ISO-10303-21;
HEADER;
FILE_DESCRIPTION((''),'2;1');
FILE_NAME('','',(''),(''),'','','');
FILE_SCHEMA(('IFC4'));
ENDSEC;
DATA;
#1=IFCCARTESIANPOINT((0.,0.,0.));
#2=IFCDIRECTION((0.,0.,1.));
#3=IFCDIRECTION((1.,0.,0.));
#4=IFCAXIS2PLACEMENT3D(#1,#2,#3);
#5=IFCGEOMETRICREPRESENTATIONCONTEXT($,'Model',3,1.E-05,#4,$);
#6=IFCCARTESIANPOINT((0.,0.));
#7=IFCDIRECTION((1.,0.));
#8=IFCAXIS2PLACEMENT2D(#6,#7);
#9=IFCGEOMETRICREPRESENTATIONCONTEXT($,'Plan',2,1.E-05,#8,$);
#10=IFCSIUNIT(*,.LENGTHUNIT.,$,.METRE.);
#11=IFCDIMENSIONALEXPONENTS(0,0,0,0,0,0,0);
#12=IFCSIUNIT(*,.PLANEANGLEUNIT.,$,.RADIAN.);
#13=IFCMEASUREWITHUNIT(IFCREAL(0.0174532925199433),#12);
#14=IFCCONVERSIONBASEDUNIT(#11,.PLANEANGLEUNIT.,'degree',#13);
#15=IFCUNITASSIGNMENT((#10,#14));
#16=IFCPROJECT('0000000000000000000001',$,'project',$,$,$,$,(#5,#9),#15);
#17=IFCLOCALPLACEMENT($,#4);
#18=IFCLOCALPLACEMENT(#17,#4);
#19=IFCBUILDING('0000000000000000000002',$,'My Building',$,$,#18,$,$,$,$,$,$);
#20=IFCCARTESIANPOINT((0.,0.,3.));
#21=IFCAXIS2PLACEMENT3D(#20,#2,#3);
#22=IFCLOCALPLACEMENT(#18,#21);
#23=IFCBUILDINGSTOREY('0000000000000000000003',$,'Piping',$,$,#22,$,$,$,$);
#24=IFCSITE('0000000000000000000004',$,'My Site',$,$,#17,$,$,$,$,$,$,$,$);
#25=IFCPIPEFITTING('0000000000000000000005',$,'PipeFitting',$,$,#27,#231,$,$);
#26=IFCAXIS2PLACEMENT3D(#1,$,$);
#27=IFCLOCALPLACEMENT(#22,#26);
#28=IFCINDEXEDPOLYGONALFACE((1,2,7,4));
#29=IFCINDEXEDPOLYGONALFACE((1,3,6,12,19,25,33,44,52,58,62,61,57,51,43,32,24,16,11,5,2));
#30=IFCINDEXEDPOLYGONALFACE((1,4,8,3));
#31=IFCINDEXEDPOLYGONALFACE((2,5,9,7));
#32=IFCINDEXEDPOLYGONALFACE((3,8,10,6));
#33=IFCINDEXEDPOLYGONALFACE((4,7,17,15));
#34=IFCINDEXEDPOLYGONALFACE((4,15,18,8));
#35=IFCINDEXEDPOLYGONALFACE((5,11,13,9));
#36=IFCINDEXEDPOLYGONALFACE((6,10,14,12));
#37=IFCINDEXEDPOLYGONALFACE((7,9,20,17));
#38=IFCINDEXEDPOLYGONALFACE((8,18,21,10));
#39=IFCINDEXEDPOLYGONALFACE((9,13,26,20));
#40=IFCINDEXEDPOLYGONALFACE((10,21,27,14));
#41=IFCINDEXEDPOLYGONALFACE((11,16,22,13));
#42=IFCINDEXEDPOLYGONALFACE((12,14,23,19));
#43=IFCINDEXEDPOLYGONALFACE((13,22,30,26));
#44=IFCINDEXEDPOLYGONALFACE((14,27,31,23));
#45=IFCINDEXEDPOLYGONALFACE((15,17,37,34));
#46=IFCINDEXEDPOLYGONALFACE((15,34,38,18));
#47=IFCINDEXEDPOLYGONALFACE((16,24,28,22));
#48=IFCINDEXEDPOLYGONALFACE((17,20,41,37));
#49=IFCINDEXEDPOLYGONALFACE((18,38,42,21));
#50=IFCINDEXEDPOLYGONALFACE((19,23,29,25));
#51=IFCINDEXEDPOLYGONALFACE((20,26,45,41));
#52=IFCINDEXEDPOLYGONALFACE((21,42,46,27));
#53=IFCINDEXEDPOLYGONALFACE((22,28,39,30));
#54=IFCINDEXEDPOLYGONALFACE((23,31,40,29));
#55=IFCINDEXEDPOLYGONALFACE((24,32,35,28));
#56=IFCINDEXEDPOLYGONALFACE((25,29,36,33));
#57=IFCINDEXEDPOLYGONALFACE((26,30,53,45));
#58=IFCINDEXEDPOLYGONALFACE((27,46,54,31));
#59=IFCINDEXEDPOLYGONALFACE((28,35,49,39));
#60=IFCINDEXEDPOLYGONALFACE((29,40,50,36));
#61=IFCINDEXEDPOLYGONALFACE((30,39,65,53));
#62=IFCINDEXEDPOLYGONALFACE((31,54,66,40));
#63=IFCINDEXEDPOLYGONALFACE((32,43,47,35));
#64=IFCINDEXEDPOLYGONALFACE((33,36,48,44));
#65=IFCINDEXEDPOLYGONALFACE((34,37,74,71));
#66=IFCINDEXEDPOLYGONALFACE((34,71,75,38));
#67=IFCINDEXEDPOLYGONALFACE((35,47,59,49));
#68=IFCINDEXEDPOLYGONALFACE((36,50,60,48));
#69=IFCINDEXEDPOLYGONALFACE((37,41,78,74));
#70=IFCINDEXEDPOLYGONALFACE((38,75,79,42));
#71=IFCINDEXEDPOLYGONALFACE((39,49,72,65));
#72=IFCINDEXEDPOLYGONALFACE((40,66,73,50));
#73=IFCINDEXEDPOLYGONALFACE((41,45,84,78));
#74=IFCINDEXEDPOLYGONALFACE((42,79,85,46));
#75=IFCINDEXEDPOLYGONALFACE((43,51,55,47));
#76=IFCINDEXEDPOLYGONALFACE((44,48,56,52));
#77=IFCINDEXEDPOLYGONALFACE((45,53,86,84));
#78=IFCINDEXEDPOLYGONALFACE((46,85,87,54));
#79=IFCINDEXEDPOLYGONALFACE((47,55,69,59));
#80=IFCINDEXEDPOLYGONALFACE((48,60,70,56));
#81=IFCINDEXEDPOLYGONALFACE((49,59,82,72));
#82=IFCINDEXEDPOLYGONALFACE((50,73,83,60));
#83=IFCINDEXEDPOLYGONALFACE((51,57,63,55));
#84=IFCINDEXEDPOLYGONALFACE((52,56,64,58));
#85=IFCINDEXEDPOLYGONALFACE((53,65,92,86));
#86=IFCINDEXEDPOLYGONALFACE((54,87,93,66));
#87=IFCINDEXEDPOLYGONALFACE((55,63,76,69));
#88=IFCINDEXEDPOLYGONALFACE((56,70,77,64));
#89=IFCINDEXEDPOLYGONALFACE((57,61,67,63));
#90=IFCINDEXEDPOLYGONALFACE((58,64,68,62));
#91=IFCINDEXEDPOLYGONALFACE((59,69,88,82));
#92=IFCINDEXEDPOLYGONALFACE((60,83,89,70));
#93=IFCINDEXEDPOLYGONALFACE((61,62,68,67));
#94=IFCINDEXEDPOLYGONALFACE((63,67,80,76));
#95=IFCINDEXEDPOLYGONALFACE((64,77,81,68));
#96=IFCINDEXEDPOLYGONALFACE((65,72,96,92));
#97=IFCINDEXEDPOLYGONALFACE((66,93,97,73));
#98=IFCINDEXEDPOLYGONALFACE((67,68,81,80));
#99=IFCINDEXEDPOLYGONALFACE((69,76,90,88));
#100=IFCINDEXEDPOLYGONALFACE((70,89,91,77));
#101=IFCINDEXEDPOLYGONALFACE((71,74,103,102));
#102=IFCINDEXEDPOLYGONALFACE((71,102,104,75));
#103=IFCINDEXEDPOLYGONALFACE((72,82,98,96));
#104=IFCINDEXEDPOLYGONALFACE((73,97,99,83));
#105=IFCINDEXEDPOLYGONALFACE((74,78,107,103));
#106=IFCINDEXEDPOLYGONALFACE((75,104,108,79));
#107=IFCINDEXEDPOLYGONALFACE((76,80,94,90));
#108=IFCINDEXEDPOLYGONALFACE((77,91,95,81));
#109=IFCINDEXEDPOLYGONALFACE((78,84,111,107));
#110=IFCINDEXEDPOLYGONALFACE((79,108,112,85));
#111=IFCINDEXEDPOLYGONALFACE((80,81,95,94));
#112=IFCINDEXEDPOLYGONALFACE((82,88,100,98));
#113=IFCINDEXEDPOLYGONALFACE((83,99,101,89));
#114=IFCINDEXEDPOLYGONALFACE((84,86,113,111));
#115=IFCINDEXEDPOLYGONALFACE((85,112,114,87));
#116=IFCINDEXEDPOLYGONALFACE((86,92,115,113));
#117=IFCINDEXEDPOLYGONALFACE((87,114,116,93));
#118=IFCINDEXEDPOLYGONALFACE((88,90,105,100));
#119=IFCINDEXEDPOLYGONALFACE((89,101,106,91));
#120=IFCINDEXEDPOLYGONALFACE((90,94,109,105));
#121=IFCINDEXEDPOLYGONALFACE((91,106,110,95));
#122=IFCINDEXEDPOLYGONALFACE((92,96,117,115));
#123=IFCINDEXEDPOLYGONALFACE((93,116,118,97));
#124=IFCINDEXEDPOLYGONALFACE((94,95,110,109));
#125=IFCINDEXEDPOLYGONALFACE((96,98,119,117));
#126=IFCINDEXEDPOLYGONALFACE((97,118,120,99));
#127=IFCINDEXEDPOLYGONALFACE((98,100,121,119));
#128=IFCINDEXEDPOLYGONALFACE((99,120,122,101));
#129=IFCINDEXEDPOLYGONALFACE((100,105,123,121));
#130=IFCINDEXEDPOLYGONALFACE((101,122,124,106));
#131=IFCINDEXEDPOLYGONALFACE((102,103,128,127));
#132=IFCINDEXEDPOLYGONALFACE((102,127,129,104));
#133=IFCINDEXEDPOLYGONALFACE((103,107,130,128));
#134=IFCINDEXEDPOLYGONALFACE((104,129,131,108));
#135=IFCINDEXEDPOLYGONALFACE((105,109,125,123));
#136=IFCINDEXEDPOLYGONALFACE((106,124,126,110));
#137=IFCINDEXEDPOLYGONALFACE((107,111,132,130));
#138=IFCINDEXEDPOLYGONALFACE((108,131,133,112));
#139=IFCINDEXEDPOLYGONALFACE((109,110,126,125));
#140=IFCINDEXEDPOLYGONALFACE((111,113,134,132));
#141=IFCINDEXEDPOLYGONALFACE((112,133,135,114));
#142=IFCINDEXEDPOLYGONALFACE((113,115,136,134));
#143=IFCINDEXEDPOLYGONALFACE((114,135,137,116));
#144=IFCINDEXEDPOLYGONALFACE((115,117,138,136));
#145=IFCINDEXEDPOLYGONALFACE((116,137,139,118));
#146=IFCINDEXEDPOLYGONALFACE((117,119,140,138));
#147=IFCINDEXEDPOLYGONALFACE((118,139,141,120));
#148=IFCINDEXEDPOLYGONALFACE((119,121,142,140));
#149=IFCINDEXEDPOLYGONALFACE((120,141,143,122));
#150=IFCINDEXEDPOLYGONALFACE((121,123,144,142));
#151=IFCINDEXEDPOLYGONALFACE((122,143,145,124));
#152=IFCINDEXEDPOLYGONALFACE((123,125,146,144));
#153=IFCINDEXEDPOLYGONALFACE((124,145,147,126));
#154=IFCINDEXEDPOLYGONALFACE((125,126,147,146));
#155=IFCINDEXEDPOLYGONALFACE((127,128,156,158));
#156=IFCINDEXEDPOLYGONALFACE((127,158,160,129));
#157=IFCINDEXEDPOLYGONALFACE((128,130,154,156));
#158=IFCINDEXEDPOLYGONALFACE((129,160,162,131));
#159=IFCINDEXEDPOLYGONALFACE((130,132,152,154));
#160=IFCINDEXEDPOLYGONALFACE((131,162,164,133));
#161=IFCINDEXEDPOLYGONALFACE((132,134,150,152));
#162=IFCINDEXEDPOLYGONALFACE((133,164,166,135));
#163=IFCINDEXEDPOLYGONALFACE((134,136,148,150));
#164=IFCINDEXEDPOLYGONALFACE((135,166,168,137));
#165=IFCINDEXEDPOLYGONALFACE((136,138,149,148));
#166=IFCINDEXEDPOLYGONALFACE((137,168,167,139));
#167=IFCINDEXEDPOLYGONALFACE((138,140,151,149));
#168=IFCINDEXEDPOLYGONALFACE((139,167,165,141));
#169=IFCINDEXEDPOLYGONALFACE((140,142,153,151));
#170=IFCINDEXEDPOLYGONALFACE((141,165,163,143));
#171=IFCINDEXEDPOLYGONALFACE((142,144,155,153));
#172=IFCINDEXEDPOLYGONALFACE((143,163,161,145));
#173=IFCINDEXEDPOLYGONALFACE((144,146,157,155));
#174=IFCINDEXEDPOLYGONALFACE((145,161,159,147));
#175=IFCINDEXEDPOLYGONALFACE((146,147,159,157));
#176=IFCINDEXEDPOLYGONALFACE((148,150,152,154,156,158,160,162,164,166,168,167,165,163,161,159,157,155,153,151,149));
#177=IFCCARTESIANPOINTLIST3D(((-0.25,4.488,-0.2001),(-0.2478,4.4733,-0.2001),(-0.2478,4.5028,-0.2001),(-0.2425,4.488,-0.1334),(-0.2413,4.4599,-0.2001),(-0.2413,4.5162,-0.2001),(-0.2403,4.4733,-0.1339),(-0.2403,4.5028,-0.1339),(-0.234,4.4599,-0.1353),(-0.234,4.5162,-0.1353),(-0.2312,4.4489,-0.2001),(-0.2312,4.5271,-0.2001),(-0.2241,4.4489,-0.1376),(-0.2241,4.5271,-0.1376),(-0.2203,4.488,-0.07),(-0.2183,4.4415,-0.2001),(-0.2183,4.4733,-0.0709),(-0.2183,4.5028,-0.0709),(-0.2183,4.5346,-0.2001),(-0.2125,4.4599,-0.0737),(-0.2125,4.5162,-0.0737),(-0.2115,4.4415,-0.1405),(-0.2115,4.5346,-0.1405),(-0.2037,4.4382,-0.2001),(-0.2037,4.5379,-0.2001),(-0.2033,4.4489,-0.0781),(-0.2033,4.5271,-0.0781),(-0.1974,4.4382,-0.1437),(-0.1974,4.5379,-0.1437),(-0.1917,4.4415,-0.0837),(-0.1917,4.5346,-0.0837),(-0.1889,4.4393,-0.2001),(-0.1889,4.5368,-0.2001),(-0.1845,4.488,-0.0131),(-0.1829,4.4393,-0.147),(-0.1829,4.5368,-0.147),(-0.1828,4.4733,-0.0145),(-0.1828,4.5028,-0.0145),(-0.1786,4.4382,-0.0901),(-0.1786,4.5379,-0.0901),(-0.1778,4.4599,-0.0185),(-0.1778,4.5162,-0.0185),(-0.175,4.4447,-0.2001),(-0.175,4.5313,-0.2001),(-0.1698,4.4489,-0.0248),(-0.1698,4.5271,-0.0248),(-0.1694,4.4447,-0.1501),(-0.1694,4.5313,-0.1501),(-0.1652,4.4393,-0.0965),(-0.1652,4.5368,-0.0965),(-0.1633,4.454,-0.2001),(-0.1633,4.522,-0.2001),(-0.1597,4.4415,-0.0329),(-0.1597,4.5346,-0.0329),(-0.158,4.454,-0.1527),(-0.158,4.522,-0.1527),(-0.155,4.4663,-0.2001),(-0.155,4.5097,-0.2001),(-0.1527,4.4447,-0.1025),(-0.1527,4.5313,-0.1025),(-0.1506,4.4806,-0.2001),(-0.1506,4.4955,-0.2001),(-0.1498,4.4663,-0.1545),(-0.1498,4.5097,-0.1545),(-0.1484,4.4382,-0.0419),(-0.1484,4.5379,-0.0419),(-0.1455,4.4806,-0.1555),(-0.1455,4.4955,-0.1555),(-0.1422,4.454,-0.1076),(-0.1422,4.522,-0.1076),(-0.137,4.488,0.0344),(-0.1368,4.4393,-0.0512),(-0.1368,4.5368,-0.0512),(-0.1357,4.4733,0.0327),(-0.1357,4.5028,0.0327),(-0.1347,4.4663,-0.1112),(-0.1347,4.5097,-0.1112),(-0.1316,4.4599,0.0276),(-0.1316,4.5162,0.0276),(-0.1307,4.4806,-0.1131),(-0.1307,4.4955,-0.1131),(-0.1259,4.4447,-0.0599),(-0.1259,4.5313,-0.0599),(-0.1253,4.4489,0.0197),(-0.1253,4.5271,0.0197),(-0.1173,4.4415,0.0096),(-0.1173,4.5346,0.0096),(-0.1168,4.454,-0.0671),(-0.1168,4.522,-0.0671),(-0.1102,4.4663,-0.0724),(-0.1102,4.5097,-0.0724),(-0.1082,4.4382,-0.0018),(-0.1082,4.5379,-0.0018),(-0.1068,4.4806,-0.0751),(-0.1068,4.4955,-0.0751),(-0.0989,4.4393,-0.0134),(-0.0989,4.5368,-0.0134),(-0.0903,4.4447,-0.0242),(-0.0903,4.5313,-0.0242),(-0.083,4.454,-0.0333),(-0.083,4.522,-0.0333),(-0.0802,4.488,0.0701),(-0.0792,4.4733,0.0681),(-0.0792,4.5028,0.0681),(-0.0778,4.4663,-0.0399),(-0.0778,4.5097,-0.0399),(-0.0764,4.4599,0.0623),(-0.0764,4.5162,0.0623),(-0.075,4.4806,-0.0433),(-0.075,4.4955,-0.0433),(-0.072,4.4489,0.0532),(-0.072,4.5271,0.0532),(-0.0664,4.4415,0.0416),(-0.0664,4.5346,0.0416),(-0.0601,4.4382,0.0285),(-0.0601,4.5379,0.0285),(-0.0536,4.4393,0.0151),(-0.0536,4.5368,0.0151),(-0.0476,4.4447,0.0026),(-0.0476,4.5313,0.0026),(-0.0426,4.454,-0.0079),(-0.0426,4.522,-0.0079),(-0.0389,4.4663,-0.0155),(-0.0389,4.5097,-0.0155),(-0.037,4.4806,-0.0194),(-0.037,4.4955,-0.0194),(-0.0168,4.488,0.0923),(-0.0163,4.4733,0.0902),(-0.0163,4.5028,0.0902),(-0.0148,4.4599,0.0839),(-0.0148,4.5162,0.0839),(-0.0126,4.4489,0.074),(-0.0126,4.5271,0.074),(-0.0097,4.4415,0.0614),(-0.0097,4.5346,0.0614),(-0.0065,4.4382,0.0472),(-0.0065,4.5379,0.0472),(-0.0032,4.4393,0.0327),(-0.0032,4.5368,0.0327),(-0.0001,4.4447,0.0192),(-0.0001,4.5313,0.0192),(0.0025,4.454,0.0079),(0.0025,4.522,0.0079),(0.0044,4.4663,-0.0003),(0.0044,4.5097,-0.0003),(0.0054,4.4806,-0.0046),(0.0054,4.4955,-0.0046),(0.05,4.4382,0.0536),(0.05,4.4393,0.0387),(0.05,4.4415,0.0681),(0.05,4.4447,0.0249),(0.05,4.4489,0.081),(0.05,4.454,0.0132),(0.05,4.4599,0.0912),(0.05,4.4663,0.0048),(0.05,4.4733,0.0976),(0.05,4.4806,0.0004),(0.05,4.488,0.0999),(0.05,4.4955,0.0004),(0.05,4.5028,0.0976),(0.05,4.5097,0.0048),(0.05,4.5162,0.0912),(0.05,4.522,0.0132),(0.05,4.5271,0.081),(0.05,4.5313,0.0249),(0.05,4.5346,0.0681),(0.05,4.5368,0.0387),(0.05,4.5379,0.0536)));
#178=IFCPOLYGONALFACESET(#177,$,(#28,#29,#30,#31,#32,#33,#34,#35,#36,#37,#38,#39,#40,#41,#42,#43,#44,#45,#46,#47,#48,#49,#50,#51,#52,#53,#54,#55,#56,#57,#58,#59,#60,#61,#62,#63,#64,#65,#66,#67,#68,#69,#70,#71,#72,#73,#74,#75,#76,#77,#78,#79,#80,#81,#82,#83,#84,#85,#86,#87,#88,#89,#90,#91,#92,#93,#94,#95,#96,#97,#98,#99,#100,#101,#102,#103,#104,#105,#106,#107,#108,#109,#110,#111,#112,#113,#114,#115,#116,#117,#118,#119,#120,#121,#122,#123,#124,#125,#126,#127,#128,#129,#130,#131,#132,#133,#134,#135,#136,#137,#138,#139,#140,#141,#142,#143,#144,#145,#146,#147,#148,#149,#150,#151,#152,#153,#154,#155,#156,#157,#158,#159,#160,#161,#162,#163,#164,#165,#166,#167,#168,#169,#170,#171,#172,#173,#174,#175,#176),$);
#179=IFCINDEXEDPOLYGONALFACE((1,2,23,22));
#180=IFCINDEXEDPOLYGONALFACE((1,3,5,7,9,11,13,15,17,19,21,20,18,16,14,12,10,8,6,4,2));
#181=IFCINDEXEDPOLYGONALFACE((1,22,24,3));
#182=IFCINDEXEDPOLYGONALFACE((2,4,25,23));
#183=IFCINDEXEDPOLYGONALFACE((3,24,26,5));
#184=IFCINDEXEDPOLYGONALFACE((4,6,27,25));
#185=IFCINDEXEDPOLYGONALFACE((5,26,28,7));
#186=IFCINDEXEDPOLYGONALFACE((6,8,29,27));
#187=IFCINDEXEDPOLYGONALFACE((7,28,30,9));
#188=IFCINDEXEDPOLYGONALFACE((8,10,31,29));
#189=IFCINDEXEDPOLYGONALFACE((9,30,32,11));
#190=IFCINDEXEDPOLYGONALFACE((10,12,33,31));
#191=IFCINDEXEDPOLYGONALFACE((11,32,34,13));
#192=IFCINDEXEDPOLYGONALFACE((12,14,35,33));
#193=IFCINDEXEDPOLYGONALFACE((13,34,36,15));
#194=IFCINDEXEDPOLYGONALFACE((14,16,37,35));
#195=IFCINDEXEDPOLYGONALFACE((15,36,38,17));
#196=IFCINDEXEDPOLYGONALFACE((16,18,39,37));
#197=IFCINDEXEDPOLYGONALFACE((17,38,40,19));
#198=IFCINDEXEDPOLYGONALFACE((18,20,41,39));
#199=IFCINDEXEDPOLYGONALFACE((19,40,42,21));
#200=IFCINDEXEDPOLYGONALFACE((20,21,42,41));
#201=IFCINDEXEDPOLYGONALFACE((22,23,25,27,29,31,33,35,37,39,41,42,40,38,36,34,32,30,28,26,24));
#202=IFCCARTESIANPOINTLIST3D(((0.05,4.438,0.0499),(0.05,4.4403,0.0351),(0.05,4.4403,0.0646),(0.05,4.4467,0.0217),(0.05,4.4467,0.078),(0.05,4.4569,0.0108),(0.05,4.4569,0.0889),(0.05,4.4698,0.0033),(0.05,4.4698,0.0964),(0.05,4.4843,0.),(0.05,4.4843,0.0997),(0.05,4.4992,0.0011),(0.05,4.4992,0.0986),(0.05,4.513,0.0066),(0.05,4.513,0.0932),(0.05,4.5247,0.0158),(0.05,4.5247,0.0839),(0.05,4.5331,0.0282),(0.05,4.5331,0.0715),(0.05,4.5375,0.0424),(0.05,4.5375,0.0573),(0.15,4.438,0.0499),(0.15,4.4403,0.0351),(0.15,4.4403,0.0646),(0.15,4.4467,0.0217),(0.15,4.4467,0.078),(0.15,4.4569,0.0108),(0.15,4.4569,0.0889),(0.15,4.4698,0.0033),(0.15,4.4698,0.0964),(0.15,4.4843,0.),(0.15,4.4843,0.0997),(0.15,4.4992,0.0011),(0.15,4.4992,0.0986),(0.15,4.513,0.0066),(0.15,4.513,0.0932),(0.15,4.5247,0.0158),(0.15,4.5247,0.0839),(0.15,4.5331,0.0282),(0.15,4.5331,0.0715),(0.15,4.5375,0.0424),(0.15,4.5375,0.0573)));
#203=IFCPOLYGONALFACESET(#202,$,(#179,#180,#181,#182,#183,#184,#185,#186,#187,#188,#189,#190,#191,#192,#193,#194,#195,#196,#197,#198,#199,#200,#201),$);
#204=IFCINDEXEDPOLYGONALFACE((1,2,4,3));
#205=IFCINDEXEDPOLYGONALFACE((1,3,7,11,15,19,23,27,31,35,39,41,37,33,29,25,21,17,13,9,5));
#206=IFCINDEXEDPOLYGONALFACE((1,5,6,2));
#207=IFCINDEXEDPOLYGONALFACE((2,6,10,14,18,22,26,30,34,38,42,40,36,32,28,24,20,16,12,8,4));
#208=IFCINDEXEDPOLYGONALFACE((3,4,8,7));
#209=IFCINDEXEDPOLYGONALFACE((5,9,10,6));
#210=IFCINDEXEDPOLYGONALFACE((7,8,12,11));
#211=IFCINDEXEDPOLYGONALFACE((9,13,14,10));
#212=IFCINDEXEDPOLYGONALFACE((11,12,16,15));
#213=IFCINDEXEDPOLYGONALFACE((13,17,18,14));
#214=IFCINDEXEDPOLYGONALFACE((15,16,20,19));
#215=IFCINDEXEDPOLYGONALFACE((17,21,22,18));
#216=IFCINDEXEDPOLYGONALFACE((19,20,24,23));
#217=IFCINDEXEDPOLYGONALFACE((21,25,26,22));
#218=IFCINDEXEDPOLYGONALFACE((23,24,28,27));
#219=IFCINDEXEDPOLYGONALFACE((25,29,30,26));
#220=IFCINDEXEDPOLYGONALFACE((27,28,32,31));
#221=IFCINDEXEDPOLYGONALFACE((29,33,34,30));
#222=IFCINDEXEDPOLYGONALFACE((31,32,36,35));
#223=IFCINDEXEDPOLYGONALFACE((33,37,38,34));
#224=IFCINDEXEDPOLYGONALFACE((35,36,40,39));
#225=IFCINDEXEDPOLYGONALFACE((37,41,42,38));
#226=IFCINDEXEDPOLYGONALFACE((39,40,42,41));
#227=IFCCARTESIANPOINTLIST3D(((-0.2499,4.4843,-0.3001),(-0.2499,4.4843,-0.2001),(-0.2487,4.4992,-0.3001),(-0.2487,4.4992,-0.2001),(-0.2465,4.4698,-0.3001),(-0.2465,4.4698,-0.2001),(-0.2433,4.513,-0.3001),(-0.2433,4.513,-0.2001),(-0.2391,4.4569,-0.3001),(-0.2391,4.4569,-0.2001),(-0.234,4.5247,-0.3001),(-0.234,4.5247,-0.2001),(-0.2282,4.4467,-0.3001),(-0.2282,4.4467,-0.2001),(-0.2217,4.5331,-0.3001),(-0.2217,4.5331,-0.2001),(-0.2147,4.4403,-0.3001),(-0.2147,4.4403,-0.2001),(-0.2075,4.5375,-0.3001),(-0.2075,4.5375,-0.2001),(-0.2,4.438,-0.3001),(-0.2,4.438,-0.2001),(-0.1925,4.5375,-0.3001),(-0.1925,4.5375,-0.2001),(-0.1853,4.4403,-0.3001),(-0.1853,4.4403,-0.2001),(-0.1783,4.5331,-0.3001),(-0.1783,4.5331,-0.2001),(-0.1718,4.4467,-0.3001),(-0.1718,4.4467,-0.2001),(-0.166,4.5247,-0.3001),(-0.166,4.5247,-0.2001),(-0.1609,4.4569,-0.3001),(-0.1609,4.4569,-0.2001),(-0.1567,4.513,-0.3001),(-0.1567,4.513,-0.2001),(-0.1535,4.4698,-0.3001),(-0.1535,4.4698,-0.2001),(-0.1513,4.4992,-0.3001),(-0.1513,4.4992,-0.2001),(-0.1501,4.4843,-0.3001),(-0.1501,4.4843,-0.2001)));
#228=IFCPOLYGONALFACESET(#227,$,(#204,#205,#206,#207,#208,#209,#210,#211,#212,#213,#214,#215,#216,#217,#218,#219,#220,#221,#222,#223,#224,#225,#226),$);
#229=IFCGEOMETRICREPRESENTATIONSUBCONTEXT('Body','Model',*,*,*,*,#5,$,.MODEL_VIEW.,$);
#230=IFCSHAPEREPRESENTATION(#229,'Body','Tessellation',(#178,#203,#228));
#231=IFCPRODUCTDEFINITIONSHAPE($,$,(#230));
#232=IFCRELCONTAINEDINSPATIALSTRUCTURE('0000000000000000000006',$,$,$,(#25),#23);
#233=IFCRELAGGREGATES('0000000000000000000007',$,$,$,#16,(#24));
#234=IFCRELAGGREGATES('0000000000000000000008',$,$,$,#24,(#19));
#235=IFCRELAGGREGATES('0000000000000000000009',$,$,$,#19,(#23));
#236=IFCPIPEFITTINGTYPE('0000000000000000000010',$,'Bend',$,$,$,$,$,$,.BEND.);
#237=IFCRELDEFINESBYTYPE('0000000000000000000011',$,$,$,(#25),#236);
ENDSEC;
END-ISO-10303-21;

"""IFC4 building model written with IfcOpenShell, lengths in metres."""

from ifc_helpers import new_model, entity, si_unit, converted_unit, frame, origin_with_axes, origin_2d_with_axis, place, context, subcontext, project, spatial, circle, extrude, source, transform, mapped, type_object, type_shapes, element, save


model = new_model("IFC4")

# Units and contexts
model_context = context("Model", 3, precision=1e-05, world=origin_with_axes())
plan_context = context("Plan", 2, precision=1e-05, world=origin_2d_with_axis())
body_context = subcontext(model_context, "Body", "Model", "MODEL_VIEW")
ifc_project = project(units=[si_unit("LENGTHUNIT", "METRE"), converted_unit("PLANEANGLEUNIT", "degree", entity("IfcReal", 0.0174532925199433), si_unit("PLANEANGLEUNIT", "RADIAN"), dimensions=[0, 0, 0, 0, 0, 0, 0])], contexts=[model_context, plan_context])

# Site, building, storey
site_placement = place(None, origin_with_axes())
site = spatial("IfcSite", under=ifc_project, at=site_placement, Name="My Site")
building_placement = place(site_placement, origin_with_axes())
building = spatial("IfcBuilding", under=site, at=building_placement, Name="My Building")
storey_placement = place(building_placement, frame((0.0, 0.0, 3.0), z_axis=(0.0, 0.0, 1.0), x_axis=(1.0, 0.0, 0.0)))
storey = spatial("IfcBuildingStorey", under=building, at=storey_placement, Name="Piping")

# Pipe fitting
pipe_fitting_type_1 = type_object("IfcPipeFittingType", Name="Bend", PredefinedType="BEND")
shared_shape = source(origin_with_axes(), body_context, "Body", "SolidModel", [
    entity("IfcSweptDiskSolid", entity("IfcIndexedPolyCurve", entity("IfcCartesianPointList3D", [[0.0, 0.0, 0.1], [0.0, -0.0732, 0.2768], [0.0, -0.25, 0.35]]), [entity("IfcArcIndex", [1, 2, 3])]), 0.05),
    extrude(circle(Radius=0.05), origin_with_axes(), (0.0, 0.0, 1.0), 0.1),
    extrude(circle(Radius=0.05), frame((0.0, -0.25, 0.35), z_axis=(0.0, -1.0, -0.000003), x_axis=(1.0, 0.0, 0.0)), (0.0, 0.0, 1.0), 0.1),
])
type_shapes(pipe_fitting_type_1, [shared_shape])
for number, where, z_axis, x_axis, name in (
    (1, (0.15, 4.488, 0.0499), (-1.0, 0.0, 0.0), (0.0, -1.0, 0.0), "PipeFitting"),
):
    element("IfcPipeFitting", number, at=place(storey_placement, frame(where, z_axis=z_axis, x_axis=x_axis)), inside=storey, type_object=pipe_fitting_type_1, Name=name, context=body_context, shape_type="MappedRepresentation", body=[
        mapped(shared_shape, transform((0.0, 0.0, 0.0), x_axis=(1.0, 0.0, 0.0), y_axis=(0.0, 1.0, 0.0), z_axis=(0.0, 0.0, 1.0), scale=1.0)),
    ])

save(model, "model.ifc")
